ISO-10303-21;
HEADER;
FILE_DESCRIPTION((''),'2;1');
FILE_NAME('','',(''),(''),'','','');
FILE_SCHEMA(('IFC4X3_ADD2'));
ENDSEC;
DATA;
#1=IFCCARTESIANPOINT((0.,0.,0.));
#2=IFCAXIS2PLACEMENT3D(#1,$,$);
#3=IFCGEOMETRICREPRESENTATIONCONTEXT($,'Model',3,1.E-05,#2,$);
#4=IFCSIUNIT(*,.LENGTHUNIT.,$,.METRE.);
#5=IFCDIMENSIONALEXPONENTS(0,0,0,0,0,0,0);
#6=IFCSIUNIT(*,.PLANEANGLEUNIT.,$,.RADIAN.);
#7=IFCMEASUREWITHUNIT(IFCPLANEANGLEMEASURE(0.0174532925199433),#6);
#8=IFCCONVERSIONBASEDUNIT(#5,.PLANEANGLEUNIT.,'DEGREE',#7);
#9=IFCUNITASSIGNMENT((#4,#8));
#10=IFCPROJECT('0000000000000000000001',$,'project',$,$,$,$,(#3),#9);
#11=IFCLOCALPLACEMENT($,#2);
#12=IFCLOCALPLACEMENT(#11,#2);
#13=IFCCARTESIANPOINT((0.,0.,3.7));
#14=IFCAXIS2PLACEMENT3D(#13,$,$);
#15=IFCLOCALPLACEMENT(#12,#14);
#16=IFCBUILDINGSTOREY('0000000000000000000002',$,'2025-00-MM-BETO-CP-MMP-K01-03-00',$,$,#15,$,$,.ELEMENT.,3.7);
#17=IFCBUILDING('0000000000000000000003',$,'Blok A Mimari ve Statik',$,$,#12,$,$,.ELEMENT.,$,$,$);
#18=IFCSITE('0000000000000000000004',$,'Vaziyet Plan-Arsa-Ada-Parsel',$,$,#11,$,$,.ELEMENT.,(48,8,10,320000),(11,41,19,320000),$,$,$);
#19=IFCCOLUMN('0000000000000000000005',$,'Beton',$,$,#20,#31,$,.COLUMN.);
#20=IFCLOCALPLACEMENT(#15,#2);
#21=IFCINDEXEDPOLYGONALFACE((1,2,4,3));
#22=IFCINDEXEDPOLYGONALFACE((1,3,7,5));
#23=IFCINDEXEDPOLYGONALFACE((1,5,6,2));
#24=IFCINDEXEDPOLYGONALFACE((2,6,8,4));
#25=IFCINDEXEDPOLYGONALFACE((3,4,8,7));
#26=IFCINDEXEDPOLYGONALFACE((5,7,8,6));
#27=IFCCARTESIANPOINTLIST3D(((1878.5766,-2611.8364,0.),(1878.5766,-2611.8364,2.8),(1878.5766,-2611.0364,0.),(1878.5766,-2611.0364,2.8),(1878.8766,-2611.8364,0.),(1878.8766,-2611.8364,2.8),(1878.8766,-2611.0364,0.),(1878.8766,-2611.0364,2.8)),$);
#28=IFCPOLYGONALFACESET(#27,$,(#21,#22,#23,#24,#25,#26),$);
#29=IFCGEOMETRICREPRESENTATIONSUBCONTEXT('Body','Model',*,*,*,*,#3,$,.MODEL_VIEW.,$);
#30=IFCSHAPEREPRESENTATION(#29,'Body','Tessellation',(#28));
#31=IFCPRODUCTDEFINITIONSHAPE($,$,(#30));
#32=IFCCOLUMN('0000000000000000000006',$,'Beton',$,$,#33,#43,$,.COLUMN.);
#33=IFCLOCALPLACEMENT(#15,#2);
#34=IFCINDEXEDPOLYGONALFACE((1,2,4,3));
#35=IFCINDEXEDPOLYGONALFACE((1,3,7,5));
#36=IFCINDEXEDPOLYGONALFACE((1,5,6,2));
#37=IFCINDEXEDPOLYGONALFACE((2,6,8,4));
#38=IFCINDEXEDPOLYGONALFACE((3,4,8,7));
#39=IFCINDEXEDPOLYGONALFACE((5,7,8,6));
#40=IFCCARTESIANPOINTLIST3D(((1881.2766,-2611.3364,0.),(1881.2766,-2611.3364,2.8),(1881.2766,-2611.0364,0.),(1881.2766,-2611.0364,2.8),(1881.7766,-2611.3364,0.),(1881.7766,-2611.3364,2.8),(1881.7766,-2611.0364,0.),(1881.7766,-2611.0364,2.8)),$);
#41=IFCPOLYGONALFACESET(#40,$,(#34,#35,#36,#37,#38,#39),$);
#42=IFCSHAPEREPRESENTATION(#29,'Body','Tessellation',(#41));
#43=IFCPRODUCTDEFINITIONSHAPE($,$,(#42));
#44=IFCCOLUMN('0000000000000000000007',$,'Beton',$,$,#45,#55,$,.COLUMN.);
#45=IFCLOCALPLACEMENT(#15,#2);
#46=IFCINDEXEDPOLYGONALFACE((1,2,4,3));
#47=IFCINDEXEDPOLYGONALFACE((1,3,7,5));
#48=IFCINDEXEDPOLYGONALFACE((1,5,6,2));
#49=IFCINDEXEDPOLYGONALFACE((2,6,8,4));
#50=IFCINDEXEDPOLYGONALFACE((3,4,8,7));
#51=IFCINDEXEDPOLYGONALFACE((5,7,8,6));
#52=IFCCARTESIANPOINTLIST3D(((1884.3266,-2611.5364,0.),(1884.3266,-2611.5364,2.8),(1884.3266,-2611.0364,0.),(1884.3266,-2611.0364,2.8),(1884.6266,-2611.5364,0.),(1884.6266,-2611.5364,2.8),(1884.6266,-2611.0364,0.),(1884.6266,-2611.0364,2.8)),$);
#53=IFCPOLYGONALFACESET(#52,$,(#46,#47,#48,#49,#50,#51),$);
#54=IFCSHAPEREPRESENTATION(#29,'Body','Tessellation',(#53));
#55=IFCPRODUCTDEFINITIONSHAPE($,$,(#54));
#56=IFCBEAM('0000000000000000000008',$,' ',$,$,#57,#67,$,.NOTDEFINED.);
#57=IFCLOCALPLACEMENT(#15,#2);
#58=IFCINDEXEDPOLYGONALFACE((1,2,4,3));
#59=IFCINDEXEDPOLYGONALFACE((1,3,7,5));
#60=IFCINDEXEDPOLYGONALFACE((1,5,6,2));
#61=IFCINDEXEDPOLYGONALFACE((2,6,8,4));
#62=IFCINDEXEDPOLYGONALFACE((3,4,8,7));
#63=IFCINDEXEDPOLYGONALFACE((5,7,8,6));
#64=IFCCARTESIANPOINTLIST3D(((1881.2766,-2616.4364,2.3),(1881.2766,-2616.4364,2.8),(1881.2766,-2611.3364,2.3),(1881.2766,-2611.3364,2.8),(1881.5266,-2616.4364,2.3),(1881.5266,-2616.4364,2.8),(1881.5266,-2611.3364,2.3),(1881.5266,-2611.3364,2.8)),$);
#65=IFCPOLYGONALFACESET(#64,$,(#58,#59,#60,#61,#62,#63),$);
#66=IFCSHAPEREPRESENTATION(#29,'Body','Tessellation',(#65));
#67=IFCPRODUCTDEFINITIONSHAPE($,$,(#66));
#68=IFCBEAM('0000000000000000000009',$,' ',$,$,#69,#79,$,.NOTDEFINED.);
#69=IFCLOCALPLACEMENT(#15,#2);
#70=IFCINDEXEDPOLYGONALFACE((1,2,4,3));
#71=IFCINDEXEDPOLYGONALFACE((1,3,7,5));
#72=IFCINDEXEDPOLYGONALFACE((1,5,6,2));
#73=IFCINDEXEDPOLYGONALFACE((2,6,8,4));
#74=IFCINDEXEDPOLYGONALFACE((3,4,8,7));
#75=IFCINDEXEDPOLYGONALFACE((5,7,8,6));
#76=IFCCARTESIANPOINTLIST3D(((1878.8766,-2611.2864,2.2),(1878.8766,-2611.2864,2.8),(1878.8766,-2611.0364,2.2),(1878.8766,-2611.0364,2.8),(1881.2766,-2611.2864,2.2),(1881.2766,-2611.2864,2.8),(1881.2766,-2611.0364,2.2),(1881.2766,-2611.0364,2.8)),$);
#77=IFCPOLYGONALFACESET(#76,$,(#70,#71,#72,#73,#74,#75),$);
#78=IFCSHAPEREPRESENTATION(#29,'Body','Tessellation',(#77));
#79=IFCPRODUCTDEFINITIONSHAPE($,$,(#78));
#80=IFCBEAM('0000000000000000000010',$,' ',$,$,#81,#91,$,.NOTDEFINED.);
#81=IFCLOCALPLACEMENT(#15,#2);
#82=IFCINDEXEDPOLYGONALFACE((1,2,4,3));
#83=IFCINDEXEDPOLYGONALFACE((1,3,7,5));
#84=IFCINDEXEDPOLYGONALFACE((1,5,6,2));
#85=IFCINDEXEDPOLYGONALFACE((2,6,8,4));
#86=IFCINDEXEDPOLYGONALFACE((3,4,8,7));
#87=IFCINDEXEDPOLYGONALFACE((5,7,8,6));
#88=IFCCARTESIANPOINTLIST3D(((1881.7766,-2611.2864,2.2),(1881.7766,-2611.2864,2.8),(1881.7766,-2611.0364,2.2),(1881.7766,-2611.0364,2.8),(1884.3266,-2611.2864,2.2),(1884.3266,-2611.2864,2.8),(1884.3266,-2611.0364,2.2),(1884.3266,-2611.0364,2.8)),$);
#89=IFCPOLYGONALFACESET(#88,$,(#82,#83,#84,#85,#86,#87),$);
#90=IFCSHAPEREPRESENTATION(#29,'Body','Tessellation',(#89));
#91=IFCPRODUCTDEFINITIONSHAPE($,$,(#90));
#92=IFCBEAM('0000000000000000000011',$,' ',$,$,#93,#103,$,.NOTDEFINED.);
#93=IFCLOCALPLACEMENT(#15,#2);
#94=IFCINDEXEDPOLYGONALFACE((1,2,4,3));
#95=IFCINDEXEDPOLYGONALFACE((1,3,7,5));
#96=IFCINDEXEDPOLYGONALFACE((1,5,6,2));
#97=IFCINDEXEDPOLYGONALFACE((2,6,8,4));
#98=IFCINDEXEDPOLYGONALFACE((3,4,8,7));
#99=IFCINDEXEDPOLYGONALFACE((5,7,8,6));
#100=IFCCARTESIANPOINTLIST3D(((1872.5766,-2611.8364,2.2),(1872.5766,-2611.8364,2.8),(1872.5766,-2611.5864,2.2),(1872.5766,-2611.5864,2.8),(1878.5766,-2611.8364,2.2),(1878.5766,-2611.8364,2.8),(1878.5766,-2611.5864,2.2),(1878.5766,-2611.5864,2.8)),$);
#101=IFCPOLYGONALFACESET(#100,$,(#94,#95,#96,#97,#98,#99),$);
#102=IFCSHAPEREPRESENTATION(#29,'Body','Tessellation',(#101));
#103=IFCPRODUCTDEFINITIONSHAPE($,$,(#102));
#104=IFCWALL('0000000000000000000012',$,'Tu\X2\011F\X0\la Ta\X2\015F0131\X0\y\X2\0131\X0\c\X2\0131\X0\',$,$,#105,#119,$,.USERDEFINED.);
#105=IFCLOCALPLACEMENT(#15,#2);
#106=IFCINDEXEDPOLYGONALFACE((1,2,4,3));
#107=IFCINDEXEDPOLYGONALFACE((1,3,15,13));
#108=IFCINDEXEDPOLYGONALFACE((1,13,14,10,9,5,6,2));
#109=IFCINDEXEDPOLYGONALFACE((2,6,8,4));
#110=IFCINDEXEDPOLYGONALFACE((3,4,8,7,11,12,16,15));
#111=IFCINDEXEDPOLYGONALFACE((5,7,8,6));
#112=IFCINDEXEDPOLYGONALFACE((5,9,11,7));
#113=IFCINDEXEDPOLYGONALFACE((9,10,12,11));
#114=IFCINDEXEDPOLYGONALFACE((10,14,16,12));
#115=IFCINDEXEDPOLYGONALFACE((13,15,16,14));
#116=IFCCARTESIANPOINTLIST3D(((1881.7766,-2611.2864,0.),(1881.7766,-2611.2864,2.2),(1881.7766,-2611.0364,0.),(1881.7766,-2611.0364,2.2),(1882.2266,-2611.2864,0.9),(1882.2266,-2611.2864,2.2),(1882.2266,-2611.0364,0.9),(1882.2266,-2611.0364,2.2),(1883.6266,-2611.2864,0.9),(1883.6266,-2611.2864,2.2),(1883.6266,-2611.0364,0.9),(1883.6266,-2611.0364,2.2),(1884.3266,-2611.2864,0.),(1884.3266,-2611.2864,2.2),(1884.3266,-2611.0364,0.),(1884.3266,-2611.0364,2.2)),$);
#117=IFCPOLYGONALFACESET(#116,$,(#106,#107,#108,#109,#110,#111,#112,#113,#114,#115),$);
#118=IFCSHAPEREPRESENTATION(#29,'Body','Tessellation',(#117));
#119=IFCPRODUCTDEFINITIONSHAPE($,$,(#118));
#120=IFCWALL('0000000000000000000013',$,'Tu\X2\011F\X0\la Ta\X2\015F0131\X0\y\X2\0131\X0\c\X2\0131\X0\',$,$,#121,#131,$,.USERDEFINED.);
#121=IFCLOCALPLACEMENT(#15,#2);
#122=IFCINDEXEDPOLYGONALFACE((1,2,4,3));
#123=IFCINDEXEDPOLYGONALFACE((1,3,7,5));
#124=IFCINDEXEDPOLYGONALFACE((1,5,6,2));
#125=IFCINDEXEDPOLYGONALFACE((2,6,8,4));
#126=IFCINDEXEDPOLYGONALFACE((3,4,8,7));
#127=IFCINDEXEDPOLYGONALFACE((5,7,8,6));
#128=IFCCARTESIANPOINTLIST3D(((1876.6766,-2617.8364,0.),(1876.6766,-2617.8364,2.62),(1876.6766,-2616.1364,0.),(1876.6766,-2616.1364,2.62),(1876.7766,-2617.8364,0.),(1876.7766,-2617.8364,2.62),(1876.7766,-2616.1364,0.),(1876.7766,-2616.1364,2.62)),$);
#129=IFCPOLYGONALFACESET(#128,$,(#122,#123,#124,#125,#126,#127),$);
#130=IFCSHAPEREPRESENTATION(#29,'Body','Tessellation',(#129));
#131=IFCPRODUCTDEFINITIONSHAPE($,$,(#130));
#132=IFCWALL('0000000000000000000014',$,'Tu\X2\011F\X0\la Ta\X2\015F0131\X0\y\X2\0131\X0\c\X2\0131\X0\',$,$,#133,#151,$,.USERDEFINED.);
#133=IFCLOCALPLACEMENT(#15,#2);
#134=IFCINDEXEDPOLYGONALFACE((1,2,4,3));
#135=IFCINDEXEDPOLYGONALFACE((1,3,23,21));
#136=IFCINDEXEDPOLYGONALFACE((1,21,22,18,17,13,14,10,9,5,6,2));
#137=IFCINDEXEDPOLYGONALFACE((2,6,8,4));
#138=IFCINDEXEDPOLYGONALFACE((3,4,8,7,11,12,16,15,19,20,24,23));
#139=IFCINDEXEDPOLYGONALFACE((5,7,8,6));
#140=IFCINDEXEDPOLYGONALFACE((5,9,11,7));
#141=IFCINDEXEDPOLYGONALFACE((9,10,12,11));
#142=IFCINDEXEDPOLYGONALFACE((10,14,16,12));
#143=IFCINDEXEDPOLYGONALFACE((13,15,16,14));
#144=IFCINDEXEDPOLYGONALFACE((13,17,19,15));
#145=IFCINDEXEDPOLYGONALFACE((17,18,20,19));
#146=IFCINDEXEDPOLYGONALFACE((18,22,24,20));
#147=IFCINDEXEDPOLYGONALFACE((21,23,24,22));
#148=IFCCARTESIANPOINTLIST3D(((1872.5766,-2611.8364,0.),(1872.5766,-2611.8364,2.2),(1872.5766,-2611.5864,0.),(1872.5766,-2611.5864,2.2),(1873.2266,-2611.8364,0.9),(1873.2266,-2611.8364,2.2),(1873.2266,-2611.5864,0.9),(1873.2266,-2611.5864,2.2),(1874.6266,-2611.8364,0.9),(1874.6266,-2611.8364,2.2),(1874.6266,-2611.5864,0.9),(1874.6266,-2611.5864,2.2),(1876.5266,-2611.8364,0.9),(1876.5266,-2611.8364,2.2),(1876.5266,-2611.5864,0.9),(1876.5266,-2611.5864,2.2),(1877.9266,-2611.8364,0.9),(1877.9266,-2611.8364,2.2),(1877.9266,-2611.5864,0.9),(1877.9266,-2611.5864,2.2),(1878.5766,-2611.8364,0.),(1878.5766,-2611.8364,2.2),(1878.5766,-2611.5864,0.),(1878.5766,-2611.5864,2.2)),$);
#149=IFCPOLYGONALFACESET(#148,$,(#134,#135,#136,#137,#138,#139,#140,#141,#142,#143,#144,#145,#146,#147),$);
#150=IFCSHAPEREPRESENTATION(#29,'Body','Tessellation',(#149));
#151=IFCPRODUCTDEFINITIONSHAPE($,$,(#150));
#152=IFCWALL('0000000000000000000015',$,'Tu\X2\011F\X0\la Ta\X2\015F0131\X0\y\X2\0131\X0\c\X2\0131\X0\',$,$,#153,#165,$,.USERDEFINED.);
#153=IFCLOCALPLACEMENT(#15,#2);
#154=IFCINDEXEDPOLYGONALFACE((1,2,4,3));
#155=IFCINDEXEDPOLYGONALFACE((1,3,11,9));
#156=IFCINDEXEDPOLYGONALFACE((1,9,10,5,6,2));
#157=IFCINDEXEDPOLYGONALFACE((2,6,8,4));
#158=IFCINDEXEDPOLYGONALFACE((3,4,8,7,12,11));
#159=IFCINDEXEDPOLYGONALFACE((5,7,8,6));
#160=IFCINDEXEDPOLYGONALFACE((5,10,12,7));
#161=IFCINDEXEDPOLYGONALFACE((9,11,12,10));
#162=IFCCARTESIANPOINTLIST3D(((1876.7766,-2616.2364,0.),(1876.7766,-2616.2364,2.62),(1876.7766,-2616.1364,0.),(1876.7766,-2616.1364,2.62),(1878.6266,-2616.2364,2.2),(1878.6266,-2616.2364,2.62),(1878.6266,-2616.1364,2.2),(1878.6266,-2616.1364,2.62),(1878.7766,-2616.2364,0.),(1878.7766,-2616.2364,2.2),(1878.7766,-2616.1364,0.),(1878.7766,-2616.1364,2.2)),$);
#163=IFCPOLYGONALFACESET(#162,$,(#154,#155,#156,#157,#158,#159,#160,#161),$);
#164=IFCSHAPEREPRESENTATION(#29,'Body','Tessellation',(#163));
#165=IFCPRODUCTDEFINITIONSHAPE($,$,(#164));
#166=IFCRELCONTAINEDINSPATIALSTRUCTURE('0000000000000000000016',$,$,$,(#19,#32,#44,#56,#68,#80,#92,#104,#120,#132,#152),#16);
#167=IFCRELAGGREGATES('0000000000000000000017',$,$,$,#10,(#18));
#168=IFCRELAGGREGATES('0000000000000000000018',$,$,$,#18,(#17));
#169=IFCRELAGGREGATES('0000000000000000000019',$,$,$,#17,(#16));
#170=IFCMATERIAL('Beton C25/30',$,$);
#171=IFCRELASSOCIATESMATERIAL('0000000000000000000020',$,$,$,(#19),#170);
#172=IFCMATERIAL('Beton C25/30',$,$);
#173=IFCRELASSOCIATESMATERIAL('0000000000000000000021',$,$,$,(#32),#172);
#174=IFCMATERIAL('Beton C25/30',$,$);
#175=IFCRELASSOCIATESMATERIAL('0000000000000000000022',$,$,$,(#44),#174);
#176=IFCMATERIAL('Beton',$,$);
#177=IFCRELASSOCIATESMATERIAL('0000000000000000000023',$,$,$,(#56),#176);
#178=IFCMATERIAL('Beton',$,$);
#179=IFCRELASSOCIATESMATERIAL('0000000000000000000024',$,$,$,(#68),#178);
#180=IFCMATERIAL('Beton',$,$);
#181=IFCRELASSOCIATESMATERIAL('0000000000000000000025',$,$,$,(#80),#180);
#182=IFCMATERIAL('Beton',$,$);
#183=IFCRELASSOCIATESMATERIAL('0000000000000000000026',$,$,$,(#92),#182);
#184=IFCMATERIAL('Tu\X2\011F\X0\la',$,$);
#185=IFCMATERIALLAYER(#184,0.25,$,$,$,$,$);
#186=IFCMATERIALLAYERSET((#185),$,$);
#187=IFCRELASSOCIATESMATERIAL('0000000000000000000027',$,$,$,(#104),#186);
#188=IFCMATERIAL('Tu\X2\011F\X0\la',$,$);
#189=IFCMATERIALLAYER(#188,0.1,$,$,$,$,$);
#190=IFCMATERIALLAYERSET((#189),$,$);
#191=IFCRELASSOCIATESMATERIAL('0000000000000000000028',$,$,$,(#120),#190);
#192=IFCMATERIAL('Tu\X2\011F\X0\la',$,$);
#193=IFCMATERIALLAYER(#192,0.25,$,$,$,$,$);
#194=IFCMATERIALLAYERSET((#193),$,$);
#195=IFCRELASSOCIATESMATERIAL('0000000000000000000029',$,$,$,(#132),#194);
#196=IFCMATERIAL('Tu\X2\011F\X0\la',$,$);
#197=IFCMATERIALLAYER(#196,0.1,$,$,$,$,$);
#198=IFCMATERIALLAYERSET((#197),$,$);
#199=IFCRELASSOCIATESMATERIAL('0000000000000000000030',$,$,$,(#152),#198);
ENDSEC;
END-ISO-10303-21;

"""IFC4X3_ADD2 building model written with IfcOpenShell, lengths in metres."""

from ifc_helpers import new_model, entity, si_unit, converted_unit, frame, frame_2d, origin, origin_with_axes, place, context, subcontext, project, spatial, polyline, rectangle, outline, extrude, clip, bounded_halfspace, material, layer, layer_set, layer_usage, element, save


model = new_model("IFC4X3_ADD2")

# Units and contexts
model_context = context("Model", 3, precision=1e-05, world=origin())
body_context = subcontext(model_context, "Body", "Model", "MODEL_VIEW")
ifc_project = project(units=[si_unit("LENGTHUNIT", "METRE"), converted_unit("PLANEANGLEUNIT", "DEGREE", entity("IfcPlaneAngleMeasure", 0.0174532925199433), si_unit("PLANEANGLEUNIT", "RADIAN"), dimensions=[0, 0, 0, 0, 0, 0, 0])], contexts=[model_context])

# Site, building, storey
site_placement = place(None, origin())
site = spatial("IfcSite", under=ifc_project, at=site_placement, Name="Vaziyet Plan-Arsa-Ada-Parsel", CompositionType="ELEMENT", RefLatitude=(48, 8, 10, 320000), RefLongitude=(11, 41, 19, 320000))
building_placement = place(site_placement, origin())
building = spatial("IfcBuilding", under=site, at=building_placement, Name="Blok A Mimari ve Statik", CompositionType="ELEMENT")
storey_placement = place(building_placement, frame((0.0, 0.0, 3.7)))
storey = spatial("IfcBuildingStorey", under=building, at=storey_placement, Name="2025-00-MM-BETO-CP-MMP-K01-03-00", CompositionType="ELEMENT", Elevation=3.7)

# Columns
ifc_material_1 = material(Name="Beton C25/30")
column_1_placement = place(storey_placement, frame((1878.5766, -2611.8364, 0.0)))
element("IfcColumn", 1, at=column_1_placement, inside=storey, material=ifc_material_1, Name="Beton", PredefinedType="COLUMN", context=body_context, shape_type="SweptSolid", body=[
    extrude(outline(polyline([(0.0, 0.0), (0.3, 0.0), (0.3, 0.8), (0.0, 0.8), (0.0, 0.0)])), origin_with_axes(), (0.0, 0.0, 1.0), 2.8),
])
ifc_material_2 = material(Name="Beton C25/30")
column_2_placement = place(storey_placement, frame((1881.2766, -2611.3364, 0.0)))
element("IfcColumn", 2, at=column_2_placement, inside=storey, material=ifc_material_2, Name="Beton", PredefinedType="COLUMN", context=body_context, shape_type="SweptSolid", body=[
    extrude(outline(polyline([(0.0, 0.3), (0.0, 0.0), (0.5, 0.0), (0.5, 0.3), (0.0, 0.3)])), origin_with_axes(), (0.0, 0.0, 1.0), 2.8),
])
ifc_material_3 = material(Name="Beton C25/30")
column_3_placement = place(storey_placement, frame((1884.3266, -2611.5364, 0.0)))
element("IfcColumn", 3, at=column_3_placement, inside=storey, material=ifc_material_3, Name="Beton", PredefinedType="COLUMN", context=body_context, shape_type="SweptSolid", body=[
    extrude(outline(polyline([(0.0, 0.5), (0.0, 0.0), (0.3, 0.0), (0.3, 0.5), (0.0, 0.5)])), origin_with_axes(), (0.0, 0.0, 1.0), 2.8),
])

# Beams
ifc_material_4 = material(Name="Beton")
beam_1_placement = place(storey_placement, frame((1881.2766, -2611.3364, 2.3), z_axis=(0.0, 0.0, 1.0), x_axis=(0.0, -1.0, 0.0)))
element("IfcBeam", 4, at=beam_1_placement, inside=storey, material=ifc_material_4, Name=" ", PredefinedType="NOTDEFINED", context=body_context, shape_type="SweptSolid", body=[
    extrude(rectangle(XDim=0.25, YDim=0.5, at=frame_2d((0.125, 0.25), x_axis=(1.0, 0.0))), frame((0.0, 0.0, 0.0), z_axis=(1.0, 0.0, 0.0), x_axis=(0.0, 1.0, 0.0)), (0.0, 0.0, 1.0), 5.1),
])
ifc_material_5 = material(Name="Beton")
beam_2_placement = place(storey_placement, frame((1881.2766, -2611.0364, 2.2), z_axis=(0.0, 0.0, 1.0), x_axis=(-1.0, 0.0, 0.0)))
element("IfcBeam", 5, at=beam_2_placement, inside=storey, material=ifc_material_5, Name=" ", PredefinedType="NOTDEFINED", context=body_context, shape_type="SweptSolid", body=[
    extrude(rectangle(XDim=0.25, YDim=0.6, at=frame_2d((0.125, 0.3), x_axis=(1.0, 0.0))), frame((0.0, 0.0, 0.0), z_axis=(1.0, 0.0, 0.0), x_axis=(0.0, 1.0, 0.0)), (0.0, 0.0, 1.0), 2.4),
])
ifc_material_6 = material(Name="Beton")
beam_3_placement = place(storey_placement, frame((1884.3266, -2611.0364, 2.2), z_axis=(0.0, 0.0, 1.0), x_axis=(-1.0, 0.0, 0.0)))
element("IfcBeam", 6, at=beam_3_placement, inside=storey, material=ifc_material_6, Name=" ", PredefinedType="NOTDEFINED", context=body_context, shape_type="SweptSolid", body=[
    extrude(rectangle(XDim=0.25, YDim=0.6, at=frame_2d((0.125, 0.3), x_axis=(1.0, 0.0))), frame((0.0, 0.0, 0.0), z_axis=(1.0, 0.0, 0.0), x_axis=(0.0, 1.0, 0.0)), (0.0, 0.0, 1.0), 2.55),
])
ifc_material_7 = material(Name="Beton")
beam_4_placement = place(storey_placement, frame((1878.5766, -2611.5864, 2.2), z_axis=(0.0, 0.0, 1.0), x_axis=(-1.0, 0.0, 0.0)))
element("IfcBeam", 7, at=beam_4_placement, inside=storey, material=ifc_material_7, Name=" ", PredefinedType="NOTDEFINED", context=body_context, shape_type="SweptSolid", body=[
    extrude(rectangle(XDim=0.25, YDim=0.6, at=frame_2d((0.125, 0.3), x_axis=(1.0, 0.0))), frame((0.0, 0.0, 0.0), z_axis=(1.0, 0.0, 0.0), x_axis=(0.0, 1.0, 0.0)), (0.0, 0.0, 1.0), 6.0),
])

# Wall, opening
ifc_material_8 = material(Name="Tuğla")
ifc_layer_1 = layer(ifc_material_8, 0.25)
ifc_layer_set_1 = layer_set([ifc_layer_1])
ifc_layer_usage_1 = layer_usage(ifc_layer_set_1, "AXIS2", "POSITIVE", 0.0)
wall_1_placement = place(storey_placement, frame((1884.3266, -2611.0364, 0.0), z_axis=(0.0, 0.0, 1.0), x_axis=(-1.0, 0.0, 0.0)))
wall_1 = element("IfcWall", 8, at=wall_1_placement, inside=storey, material=ifc_layer_usage_1, Name="Tuğla Taşıyıcı", PredefinedType="USERDEFINED", context=body_context, shape_type="SweptSolid", body=[
    extrude(outline(polyline([(-2.55, -0.25), (0.0, -0.25), (0.0, 0.0), (-0.05, 0.0), (-0.15, 0.0), (-2.55, 0.0), (-2.55, -0.25)])), frame((2.55, 0.25, 0.0), z_axis=(0.0, 0.0, 1.0), x_axis=(1.0, 0.0, 0.0)), (0.0, 0.0, 1.0), 2.2),
])
opening_1_placement = place(wall_1_placement, frame((0.7, 0.0, 0.9), z_axis=(0.0, 1.0, 0.0), x_axis=(0.0, 0.0, 1.0)))
element("IfcOpeningElement", 9, at=opening_1_placement, cuts=wall_1, PredefinedType="OPENING", context=body_context, shape_type="SweptSolid", body=[
    extrude(outline(polyline([(1.35, 1.4), (1.35, 0.0), (0.0, 0.0), (0.0, 1.4), (1.35, 1.4)])), origin_with_axes(), (0.0, 0.0, 1.0), 0.25),
])

# Wall
ifc_material_9 = material(Name="Tuğla")
ifc_layer_2 = layer(ifc_material_9, 0.1)
ifc_layer_set_2 = layer_set([ifc_layer_2])
ifc_layer_usage_2 = layer_usage(ifc_layer_set_2, "AXIS2", "POSITIVE", 0.0)
wall_2_placement = place(storey_placement, frame((1876.6766, -2616.1364, 0.0), z_axis=(0.0, 0.0, 1.0), x_axis=(0.0, -1.0, 0.0)))
element("IfcWall", 10, at=wall_2_placement, inside=storey, material=ifc_layer_usage_2, Name="Tuğla Taşıyıcı", PredefinedType="USERDEFINED", context=body_context, shape_type="SweptSolid", body=[
    extrude(rectangle(XDim=1.7, YDim=0.1, at=frame_2d((0.85, 0.05), x_axis=(1.0, 0.0))), origin_with_axes(), (0.0, 0.0, 1.0), 2.62),
])

# Wall, openings
ifc_material_10 = material(Name="Tuğla")
ifc_layer_3 = layer(ifc_material_10, 0.25)
ifc_layer_set_3 = layer_set([ifc_layer_3])
ifc_layer_usage_3 = layer_usage(ifc_layer_set_3, "AXIS2", "POSITIVE", 0.0)
wall_3_placement = place(storey_placement, frame((1878.5766, -2611.5864, 0.0), z_axis=(0.0, 0.0, 1.0), x_axis=(-1.0, 0.0, 0.0)))
wall_3 = element("IfcWall", 11, at=wall_3_placement, inside=storey, material=ifc_layer_usage_3, Name="Tuğla Taşıyıcı", PredefinedType="USERDEFINED", context=body_context, shape_type="SweptSolid", body=[
    extrude(rectangle(XDim=6.0, YDim=0.25, at=frame_2d((3.0, 0.125), x_axis=(1.0, 0.0))), origin_with_axes(), (0.0, 0.0, 1.0), 2.2),
])
opening_2_placement = place(wall_3_placement, frame((3.95, 0.0, 0.9), z_axis=(0.0, 1.0, 0.0), x_axis=(0.0, 0.0, 1.0)))
element("IfcOpeningElement", 12, at=opening_2_placement, cuts=wall_3, PredefinedType="OPENING", context=body_context, shape_type="SweptSolid", body=[
    extrude(outline(polyline([(1.35, 1.4), (1.35, 0.0), (0.0, 0.0), (0.0, 1.4), (1.35, 1.4)])), origin_with_axes(), (0.0, 0.0, 1.0), 0.25),
])
opening_3_placement = place(wall_3_placement, frame((0.65, 0.0, 0.9), z_axis=(0.0, 1.0, 0.0), x_axis=(0.0, 0.0, 1.0)))
element("IfcOpeningElement", 13, at=opening_3_placement, cuts=wall_3, PredefinedType="OPENING", context=body_context, shape_type="SweptSolid", body=[
    extrude(outline(polyline([(1.35, 1.4), (1.35, 0.0), (0.0, 0.0), (0.0, 1.4), (1.35, 1.4)])), origin_with_axes(), (0.0, 0.0, 1.0), 0.25),
])

# Wall
ifc_material_11 = material(Name="Tuğla")
ifc_layer_4 = layer(ifc_material_11, 0.1)
ifc_layer_set_4 = layer_set([ifc_layer_4])
ifc_layer_usage_4 = layer_usage(ifc_layer_set_4, "AXIS2", "POSITIVE", 0.0)
wall_4_placement = place(storey_placement, frame((1876.7766, -2616.2364, 0.0)))
element("IfcWall", 14, at=wall_4_placement, inside=storey, material=ifc_layer_usage_4, Name="Tuğla Taşıyıcı", PredefinedType="USERDEFINED", context=body_context, shape_type="Clipping", body=[
    clip(extrude(rectangle(XDim=2.0, YDim=0.1, at=frame_2d((1.0, 0.05), x_axis=(1.0, 0.0))), origin_with_axes(), (0.0, 0.0, 1.0), 2.62), bounded_halfspace(frame((1.925, 0.05, 2.2), z_axis=(0.0, 0.0, -1.0), x_axis=(0.0, -1.0, 0.0)), True, origin_with_axes(), polyline([(1.85, 0.1), (1.85, 0.0), (2.0, 0.0), (2.0, 0.1), (1.85, 0.1)]))),
])

save(model, "model.ifc")
